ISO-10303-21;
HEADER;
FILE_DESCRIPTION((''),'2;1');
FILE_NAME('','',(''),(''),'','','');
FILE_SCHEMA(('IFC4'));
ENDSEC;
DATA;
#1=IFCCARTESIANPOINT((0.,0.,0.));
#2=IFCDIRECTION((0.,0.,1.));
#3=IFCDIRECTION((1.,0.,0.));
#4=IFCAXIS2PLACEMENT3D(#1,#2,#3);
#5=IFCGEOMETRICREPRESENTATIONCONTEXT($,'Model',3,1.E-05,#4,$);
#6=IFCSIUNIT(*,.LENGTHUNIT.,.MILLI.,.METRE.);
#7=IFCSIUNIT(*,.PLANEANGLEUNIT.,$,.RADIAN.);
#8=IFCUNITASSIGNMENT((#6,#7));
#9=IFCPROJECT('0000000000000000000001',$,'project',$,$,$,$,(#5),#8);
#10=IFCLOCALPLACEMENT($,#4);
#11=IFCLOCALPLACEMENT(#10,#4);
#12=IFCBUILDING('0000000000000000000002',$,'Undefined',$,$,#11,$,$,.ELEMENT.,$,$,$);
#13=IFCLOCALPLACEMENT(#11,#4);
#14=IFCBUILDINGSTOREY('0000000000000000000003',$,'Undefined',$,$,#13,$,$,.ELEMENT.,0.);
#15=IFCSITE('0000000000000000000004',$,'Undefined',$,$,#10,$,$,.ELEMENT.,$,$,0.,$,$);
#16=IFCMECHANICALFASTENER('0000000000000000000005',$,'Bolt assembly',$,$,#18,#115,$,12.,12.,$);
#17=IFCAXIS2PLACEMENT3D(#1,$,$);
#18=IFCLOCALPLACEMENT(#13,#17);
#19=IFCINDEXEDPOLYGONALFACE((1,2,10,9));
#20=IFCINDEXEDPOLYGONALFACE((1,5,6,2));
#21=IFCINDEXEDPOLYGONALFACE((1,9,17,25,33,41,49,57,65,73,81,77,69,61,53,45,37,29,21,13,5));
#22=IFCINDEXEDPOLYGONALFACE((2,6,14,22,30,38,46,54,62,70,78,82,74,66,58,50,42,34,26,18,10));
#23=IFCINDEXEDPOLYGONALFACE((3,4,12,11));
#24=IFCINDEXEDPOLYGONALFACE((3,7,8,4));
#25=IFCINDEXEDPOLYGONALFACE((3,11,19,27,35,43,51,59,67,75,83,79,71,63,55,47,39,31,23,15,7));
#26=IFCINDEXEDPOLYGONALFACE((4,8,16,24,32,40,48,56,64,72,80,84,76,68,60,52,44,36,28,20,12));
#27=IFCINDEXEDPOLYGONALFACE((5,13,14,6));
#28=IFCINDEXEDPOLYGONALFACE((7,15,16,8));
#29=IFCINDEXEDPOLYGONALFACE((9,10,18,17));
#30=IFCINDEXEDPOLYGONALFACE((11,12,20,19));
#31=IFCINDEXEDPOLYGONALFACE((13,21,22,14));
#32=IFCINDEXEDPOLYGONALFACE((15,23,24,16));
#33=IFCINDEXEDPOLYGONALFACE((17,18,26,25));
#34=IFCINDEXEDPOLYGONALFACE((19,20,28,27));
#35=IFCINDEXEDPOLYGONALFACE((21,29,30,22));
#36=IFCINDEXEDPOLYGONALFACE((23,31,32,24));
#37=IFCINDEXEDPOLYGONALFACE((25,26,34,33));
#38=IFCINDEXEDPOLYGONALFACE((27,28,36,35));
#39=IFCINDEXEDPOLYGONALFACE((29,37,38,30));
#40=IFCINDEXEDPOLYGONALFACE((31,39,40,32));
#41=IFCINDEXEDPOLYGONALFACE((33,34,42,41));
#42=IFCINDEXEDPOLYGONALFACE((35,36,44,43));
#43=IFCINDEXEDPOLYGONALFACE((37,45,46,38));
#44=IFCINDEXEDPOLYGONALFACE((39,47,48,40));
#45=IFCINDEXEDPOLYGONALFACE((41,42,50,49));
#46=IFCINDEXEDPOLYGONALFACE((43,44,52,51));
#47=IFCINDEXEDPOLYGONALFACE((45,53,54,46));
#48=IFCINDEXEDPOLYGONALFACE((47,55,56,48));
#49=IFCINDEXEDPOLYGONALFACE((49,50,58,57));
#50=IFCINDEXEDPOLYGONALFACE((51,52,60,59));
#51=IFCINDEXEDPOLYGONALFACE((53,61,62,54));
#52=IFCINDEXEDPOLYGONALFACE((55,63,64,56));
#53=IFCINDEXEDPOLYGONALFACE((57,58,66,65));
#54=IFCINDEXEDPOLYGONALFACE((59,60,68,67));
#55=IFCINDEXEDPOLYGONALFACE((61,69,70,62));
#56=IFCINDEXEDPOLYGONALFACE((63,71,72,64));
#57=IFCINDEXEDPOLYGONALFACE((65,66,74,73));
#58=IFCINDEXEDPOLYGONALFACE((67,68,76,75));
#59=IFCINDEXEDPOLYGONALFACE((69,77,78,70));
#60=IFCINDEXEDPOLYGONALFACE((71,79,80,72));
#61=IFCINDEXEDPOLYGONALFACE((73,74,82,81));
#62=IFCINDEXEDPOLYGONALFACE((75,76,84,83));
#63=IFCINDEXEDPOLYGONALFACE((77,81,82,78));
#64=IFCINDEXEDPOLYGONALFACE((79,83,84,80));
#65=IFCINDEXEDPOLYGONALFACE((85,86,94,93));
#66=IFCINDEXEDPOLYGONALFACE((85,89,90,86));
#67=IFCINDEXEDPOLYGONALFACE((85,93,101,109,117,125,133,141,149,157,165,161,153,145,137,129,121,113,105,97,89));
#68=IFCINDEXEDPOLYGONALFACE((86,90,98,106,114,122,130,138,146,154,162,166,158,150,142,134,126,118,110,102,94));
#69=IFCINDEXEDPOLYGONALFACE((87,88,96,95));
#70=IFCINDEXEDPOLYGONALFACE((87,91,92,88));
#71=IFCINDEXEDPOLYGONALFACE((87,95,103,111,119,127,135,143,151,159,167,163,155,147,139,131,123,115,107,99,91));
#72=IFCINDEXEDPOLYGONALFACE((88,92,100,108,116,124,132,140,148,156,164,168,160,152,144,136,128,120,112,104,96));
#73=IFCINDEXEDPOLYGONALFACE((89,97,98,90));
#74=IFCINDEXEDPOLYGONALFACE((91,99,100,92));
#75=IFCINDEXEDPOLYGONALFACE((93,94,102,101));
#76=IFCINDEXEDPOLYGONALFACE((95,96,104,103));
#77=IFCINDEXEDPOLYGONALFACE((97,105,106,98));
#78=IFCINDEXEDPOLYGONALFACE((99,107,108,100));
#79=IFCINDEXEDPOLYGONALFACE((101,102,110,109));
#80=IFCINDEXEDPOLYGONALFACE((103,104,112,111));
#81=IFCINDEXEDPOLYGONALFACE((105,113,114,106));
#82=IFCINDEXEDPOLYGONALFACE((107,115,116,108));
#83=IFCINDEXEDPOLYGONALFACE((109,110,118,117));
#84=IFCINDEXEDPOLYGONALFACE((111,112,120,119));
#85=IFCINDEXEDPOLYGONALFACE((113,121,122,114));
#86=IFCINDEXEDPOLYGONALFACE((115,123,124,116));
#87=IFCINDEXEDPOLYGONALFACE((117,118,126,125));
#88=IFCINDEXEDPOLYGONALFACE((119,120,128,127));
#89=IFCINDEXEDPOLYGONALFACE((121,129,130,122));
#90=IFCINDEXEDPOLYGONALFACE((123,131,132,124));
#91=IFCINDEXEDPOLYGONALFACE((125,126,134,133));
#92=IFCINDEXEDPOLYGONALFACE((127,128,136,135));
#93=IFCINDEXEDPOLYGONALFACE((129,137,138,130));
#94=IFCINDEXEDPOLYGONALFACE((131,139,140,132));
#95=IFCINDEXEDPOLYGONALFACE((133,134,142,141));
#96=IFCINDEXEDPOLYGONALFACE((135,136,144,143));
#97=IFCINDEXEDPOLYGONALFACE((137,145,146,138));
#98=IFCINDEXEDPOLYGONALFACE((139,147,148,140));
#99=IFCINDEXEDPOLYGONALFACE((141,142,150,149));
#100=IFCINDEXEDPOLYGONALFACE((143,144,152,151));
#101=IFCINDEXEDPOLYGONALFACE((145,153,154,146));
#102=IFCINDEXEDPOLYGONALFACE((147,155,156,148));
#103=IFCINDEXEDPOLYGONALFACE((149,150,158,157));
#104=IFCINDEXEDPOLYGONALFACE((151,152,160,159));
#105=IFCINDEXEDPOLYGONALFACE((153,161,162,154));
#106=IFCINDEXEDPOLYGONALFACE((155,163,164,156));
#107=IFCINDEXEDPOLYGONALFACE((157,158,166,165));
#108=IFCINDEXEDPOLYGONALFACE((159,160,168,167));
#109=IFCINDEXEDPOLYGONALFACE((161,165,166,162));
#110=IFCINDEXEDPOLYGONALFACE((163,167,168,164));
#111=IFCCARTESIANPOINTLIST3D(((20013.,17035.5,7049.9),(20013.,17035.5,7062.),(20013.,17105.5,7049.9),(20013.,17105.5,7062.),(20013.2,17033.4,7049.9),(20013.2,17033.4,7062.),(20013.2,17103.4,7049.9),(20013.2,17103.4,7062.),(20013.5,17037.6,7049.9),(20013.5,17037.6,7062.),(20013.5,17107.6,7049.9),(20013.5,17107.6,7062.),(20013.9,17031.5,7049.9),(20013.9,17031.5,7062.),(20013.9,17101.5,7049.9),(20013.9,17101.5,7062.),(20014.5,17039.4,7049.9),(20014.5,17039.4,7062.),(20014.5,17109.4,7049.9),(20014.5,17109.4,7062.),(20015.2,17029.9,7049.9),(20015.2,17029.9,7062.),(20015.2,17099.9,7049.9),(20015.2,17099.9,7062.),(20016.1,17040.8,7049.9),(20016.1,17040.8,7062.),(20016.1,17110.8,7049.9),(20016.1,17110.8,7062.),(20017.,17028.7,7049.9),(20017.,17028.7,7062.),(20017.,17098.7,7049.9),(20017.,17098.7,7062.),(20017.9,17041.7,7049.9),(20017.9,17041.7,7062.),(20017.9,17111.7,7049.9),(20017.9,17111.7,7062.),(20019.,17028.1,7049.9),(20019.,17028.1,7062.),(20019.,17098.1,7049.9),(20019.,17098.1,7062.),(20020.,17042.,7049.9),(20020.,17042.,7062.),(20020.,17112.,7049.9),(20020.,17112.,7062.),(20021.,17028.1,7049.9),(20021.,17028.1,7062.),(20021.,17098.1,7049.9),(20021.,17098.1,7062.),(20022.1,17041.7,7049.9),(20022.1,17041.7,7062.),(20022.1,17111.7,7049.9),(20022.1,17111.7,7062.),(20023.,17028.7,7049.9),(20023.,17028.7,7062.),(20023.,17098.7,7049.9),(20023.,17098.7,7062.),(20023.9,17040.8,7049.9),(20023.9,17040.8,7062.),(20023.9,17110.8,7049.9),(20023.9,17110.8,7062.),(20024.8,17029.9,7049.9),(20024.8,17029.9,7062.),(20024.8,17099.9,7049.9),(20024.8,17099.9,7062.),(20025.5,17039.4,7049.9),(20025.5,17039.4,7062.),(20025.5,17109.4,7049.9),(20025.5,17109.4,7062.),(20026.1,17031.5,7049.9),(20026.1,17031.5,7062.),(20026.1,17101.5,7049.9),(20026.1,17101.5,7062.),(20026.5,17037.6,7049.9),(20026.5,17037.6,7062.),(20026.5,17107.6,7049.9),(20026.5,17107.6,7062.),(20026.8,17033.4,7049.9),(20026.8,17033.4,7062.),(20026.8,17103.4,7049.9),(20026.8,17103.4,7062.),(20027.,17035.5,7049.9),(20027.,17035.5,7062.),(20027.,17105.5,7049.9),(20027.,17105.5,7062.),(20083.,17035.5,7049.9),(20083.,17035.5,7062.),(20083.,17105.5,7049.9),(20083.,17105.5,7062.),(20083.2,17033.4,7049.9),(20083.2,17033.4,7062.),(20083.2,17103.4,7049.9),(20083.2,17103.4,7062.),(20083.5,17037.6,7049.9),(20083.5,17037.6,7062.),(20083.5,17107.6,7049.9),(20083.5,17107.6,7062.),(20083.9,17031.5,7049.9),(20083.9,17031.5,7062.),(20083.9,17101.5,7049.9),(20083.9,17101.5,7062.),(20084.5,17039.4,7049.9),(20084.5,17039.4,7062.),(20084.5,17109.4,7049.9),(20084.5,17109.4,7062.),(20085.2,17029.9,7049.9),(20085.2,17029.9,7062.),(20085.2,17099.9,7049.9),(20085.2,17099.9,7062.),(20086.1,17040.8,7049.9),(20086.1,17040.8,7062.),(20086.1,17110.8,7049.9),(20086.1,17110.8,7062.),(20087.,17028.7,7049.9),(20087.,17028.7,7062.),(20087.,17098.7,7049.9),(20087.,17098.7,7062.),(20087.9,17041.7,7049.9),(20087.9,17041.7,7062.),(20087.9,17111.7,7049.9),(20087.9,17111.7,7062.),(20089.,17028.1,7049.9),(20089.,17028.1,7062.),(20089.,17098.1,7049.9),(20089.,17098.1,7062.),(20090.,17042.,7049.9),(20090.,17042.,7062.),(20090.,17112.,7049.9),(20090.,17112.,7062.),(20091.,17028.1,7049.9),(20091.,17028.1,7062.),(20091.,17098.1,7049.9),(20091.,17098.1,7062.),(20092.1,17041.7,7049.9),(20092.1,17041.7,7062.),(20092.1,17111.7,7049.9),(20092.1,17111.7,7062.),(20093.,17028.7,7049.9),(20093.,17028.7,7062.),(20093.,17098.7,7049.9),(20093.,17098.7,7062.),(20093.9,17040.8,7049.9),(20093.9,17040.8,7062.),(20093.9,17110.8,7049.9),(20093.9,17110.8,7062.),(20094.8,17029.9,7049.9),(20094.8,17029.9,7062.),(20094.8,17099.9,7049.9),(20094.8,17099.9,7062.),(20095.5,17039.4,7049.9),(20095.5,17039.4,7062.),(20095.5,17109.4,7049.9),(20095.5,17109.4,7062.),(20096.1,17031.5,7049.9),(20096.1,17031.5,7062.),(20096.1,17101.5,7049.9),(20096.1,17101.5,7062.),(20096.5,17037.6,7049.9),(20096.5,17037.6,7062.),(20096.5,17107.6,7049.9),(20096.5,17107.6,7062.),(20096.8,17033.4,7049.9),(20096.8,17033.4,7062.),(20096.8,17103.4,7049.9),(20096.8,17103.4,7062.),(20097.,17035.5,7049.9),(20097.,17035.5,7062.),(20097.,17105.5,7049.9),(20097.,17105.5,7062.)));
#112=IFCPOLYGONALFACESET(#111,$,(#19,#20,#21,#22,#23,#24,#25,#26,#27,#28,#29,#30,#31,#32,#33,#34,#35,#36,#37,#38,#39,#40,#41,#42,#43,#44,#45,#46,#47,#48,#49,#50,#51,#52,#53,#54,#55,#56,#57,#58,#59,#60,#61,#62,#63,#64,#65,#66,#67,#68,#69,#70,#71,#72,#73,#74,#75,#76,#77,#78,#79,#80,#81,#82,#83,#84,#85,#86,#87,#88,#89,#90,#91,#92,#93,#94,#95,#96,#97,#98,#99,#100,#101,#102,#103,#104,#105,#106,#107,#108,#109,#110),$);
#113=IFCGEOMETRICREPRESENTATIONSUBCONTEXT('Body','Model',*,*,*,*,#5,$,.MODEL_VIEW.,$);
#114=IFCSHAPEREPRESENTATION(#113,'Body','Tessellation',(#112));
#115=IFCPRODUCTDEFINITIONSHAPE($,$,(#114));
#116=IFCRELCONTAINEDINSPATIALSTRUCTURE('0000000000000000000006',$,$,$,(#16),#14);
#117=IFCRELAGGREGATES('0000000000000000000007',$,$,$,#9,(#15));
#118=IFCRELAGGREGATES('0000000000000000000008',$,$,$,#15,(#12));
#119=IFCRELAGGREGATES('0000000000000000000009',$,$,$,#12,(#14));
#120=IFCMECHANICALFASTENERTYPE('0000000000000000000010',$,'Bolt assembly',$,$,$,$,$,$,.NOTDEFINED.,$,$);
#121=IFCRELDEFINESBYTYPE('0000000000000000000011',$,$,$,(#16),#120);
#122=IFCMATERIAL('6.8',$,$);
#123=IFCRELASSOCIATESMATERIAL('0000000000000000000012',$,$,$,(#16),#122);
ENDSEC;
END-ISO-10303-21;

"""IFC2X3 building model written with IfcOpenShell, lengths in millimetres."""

from ifc_helpers import new_model, si_unit, frame, origin_with_axes, origin_2d_with_axis, place, context, subcontext, project, spatial, circle, extrude, source, transform, mapped, material, type_object, element, save


model = new_model("IFC2X3")

# Units and contexts
model_context = context("Model", 3, precision=1e-05, world=origin_with_axes())
body_context = subcontext(model_context, "Body", "Model", "MODEL_VIEW")
ifc_project = project(units=[si_unit("LENGTHUNIT", "METRE", prefix="MILLI"), si_unit("PLANEANGLEUNIT", "RADIAN")], contexts=[model_context])

# Site, building, storey
site_placement = place(None, origin_with_axes())
site = spatial("IfcSite", under=ifc_project, at=site_placement, Name="Undefined", CompositionType="ELEMENT", RefElevation=0.0)
building_placement = place(site_placement, origin_with_axes())
building = spatial("IfcBuilding", under=site, at=building_placement, Name="Undefined", CompositionType="ELEMENT")
storey_placement = place(building_placement, origin_with_axes())
storey = spatial("IfcBuildingStorey", under=building, at=storey_placement, Name="Undefined", CompositionType="ELEMENT", Elevation=0.0)

# Mechanical fastener
ifc_material_1 = material(Name="6.8")
mechanical_fastener_type = type_object("IfcMechanicalFastenerType", Name="Bolt assembly")
shared_shape_1 = source(origin_with_axes(), body_context, "Body", "SweptSolid", [
    extrude(circle(Radius=7.0, at=origin_2d_with_axis()), frame((0.0, -12.0, 0.0), z_axis=(0.0, 1.0, 0.0), x_axis=(1.0, 0.0, 0.0)), (0.0, 0.0, 1.0), 12.1),
])
mechanical_fastener_1_placement = place(storey_placement, frame((20055.0, 17035.0, 7050.0), z_axis=(-1.0, 0.0, 0.0), x_axis=(0.0, 1.0, 0.0)))
element("IfcMechanicalFastener", 1, at=mechanical_fastener_1_placement, inside=storey, type_object=mechanical_fastener_type, material=ifc_material_1, Name="Bolt assembly", NominalDiameter=12.0, NominalLength=12.0, context=body_context, shape_type="MappedRepresentation", body=[
    mapped(shared_shape_1, transform((0.0, 0.0, -35.0))),
    mapped(shared_shape_1, transform((70.0, 0.0, -35.0))),
    mapped(shared_shape_1, transform((0.0, 0.0, 35.0))),
    mapped(shared_shape_1, transform((70.0, 0.0, 35.0))),
])

save(model, "model.ifc")
